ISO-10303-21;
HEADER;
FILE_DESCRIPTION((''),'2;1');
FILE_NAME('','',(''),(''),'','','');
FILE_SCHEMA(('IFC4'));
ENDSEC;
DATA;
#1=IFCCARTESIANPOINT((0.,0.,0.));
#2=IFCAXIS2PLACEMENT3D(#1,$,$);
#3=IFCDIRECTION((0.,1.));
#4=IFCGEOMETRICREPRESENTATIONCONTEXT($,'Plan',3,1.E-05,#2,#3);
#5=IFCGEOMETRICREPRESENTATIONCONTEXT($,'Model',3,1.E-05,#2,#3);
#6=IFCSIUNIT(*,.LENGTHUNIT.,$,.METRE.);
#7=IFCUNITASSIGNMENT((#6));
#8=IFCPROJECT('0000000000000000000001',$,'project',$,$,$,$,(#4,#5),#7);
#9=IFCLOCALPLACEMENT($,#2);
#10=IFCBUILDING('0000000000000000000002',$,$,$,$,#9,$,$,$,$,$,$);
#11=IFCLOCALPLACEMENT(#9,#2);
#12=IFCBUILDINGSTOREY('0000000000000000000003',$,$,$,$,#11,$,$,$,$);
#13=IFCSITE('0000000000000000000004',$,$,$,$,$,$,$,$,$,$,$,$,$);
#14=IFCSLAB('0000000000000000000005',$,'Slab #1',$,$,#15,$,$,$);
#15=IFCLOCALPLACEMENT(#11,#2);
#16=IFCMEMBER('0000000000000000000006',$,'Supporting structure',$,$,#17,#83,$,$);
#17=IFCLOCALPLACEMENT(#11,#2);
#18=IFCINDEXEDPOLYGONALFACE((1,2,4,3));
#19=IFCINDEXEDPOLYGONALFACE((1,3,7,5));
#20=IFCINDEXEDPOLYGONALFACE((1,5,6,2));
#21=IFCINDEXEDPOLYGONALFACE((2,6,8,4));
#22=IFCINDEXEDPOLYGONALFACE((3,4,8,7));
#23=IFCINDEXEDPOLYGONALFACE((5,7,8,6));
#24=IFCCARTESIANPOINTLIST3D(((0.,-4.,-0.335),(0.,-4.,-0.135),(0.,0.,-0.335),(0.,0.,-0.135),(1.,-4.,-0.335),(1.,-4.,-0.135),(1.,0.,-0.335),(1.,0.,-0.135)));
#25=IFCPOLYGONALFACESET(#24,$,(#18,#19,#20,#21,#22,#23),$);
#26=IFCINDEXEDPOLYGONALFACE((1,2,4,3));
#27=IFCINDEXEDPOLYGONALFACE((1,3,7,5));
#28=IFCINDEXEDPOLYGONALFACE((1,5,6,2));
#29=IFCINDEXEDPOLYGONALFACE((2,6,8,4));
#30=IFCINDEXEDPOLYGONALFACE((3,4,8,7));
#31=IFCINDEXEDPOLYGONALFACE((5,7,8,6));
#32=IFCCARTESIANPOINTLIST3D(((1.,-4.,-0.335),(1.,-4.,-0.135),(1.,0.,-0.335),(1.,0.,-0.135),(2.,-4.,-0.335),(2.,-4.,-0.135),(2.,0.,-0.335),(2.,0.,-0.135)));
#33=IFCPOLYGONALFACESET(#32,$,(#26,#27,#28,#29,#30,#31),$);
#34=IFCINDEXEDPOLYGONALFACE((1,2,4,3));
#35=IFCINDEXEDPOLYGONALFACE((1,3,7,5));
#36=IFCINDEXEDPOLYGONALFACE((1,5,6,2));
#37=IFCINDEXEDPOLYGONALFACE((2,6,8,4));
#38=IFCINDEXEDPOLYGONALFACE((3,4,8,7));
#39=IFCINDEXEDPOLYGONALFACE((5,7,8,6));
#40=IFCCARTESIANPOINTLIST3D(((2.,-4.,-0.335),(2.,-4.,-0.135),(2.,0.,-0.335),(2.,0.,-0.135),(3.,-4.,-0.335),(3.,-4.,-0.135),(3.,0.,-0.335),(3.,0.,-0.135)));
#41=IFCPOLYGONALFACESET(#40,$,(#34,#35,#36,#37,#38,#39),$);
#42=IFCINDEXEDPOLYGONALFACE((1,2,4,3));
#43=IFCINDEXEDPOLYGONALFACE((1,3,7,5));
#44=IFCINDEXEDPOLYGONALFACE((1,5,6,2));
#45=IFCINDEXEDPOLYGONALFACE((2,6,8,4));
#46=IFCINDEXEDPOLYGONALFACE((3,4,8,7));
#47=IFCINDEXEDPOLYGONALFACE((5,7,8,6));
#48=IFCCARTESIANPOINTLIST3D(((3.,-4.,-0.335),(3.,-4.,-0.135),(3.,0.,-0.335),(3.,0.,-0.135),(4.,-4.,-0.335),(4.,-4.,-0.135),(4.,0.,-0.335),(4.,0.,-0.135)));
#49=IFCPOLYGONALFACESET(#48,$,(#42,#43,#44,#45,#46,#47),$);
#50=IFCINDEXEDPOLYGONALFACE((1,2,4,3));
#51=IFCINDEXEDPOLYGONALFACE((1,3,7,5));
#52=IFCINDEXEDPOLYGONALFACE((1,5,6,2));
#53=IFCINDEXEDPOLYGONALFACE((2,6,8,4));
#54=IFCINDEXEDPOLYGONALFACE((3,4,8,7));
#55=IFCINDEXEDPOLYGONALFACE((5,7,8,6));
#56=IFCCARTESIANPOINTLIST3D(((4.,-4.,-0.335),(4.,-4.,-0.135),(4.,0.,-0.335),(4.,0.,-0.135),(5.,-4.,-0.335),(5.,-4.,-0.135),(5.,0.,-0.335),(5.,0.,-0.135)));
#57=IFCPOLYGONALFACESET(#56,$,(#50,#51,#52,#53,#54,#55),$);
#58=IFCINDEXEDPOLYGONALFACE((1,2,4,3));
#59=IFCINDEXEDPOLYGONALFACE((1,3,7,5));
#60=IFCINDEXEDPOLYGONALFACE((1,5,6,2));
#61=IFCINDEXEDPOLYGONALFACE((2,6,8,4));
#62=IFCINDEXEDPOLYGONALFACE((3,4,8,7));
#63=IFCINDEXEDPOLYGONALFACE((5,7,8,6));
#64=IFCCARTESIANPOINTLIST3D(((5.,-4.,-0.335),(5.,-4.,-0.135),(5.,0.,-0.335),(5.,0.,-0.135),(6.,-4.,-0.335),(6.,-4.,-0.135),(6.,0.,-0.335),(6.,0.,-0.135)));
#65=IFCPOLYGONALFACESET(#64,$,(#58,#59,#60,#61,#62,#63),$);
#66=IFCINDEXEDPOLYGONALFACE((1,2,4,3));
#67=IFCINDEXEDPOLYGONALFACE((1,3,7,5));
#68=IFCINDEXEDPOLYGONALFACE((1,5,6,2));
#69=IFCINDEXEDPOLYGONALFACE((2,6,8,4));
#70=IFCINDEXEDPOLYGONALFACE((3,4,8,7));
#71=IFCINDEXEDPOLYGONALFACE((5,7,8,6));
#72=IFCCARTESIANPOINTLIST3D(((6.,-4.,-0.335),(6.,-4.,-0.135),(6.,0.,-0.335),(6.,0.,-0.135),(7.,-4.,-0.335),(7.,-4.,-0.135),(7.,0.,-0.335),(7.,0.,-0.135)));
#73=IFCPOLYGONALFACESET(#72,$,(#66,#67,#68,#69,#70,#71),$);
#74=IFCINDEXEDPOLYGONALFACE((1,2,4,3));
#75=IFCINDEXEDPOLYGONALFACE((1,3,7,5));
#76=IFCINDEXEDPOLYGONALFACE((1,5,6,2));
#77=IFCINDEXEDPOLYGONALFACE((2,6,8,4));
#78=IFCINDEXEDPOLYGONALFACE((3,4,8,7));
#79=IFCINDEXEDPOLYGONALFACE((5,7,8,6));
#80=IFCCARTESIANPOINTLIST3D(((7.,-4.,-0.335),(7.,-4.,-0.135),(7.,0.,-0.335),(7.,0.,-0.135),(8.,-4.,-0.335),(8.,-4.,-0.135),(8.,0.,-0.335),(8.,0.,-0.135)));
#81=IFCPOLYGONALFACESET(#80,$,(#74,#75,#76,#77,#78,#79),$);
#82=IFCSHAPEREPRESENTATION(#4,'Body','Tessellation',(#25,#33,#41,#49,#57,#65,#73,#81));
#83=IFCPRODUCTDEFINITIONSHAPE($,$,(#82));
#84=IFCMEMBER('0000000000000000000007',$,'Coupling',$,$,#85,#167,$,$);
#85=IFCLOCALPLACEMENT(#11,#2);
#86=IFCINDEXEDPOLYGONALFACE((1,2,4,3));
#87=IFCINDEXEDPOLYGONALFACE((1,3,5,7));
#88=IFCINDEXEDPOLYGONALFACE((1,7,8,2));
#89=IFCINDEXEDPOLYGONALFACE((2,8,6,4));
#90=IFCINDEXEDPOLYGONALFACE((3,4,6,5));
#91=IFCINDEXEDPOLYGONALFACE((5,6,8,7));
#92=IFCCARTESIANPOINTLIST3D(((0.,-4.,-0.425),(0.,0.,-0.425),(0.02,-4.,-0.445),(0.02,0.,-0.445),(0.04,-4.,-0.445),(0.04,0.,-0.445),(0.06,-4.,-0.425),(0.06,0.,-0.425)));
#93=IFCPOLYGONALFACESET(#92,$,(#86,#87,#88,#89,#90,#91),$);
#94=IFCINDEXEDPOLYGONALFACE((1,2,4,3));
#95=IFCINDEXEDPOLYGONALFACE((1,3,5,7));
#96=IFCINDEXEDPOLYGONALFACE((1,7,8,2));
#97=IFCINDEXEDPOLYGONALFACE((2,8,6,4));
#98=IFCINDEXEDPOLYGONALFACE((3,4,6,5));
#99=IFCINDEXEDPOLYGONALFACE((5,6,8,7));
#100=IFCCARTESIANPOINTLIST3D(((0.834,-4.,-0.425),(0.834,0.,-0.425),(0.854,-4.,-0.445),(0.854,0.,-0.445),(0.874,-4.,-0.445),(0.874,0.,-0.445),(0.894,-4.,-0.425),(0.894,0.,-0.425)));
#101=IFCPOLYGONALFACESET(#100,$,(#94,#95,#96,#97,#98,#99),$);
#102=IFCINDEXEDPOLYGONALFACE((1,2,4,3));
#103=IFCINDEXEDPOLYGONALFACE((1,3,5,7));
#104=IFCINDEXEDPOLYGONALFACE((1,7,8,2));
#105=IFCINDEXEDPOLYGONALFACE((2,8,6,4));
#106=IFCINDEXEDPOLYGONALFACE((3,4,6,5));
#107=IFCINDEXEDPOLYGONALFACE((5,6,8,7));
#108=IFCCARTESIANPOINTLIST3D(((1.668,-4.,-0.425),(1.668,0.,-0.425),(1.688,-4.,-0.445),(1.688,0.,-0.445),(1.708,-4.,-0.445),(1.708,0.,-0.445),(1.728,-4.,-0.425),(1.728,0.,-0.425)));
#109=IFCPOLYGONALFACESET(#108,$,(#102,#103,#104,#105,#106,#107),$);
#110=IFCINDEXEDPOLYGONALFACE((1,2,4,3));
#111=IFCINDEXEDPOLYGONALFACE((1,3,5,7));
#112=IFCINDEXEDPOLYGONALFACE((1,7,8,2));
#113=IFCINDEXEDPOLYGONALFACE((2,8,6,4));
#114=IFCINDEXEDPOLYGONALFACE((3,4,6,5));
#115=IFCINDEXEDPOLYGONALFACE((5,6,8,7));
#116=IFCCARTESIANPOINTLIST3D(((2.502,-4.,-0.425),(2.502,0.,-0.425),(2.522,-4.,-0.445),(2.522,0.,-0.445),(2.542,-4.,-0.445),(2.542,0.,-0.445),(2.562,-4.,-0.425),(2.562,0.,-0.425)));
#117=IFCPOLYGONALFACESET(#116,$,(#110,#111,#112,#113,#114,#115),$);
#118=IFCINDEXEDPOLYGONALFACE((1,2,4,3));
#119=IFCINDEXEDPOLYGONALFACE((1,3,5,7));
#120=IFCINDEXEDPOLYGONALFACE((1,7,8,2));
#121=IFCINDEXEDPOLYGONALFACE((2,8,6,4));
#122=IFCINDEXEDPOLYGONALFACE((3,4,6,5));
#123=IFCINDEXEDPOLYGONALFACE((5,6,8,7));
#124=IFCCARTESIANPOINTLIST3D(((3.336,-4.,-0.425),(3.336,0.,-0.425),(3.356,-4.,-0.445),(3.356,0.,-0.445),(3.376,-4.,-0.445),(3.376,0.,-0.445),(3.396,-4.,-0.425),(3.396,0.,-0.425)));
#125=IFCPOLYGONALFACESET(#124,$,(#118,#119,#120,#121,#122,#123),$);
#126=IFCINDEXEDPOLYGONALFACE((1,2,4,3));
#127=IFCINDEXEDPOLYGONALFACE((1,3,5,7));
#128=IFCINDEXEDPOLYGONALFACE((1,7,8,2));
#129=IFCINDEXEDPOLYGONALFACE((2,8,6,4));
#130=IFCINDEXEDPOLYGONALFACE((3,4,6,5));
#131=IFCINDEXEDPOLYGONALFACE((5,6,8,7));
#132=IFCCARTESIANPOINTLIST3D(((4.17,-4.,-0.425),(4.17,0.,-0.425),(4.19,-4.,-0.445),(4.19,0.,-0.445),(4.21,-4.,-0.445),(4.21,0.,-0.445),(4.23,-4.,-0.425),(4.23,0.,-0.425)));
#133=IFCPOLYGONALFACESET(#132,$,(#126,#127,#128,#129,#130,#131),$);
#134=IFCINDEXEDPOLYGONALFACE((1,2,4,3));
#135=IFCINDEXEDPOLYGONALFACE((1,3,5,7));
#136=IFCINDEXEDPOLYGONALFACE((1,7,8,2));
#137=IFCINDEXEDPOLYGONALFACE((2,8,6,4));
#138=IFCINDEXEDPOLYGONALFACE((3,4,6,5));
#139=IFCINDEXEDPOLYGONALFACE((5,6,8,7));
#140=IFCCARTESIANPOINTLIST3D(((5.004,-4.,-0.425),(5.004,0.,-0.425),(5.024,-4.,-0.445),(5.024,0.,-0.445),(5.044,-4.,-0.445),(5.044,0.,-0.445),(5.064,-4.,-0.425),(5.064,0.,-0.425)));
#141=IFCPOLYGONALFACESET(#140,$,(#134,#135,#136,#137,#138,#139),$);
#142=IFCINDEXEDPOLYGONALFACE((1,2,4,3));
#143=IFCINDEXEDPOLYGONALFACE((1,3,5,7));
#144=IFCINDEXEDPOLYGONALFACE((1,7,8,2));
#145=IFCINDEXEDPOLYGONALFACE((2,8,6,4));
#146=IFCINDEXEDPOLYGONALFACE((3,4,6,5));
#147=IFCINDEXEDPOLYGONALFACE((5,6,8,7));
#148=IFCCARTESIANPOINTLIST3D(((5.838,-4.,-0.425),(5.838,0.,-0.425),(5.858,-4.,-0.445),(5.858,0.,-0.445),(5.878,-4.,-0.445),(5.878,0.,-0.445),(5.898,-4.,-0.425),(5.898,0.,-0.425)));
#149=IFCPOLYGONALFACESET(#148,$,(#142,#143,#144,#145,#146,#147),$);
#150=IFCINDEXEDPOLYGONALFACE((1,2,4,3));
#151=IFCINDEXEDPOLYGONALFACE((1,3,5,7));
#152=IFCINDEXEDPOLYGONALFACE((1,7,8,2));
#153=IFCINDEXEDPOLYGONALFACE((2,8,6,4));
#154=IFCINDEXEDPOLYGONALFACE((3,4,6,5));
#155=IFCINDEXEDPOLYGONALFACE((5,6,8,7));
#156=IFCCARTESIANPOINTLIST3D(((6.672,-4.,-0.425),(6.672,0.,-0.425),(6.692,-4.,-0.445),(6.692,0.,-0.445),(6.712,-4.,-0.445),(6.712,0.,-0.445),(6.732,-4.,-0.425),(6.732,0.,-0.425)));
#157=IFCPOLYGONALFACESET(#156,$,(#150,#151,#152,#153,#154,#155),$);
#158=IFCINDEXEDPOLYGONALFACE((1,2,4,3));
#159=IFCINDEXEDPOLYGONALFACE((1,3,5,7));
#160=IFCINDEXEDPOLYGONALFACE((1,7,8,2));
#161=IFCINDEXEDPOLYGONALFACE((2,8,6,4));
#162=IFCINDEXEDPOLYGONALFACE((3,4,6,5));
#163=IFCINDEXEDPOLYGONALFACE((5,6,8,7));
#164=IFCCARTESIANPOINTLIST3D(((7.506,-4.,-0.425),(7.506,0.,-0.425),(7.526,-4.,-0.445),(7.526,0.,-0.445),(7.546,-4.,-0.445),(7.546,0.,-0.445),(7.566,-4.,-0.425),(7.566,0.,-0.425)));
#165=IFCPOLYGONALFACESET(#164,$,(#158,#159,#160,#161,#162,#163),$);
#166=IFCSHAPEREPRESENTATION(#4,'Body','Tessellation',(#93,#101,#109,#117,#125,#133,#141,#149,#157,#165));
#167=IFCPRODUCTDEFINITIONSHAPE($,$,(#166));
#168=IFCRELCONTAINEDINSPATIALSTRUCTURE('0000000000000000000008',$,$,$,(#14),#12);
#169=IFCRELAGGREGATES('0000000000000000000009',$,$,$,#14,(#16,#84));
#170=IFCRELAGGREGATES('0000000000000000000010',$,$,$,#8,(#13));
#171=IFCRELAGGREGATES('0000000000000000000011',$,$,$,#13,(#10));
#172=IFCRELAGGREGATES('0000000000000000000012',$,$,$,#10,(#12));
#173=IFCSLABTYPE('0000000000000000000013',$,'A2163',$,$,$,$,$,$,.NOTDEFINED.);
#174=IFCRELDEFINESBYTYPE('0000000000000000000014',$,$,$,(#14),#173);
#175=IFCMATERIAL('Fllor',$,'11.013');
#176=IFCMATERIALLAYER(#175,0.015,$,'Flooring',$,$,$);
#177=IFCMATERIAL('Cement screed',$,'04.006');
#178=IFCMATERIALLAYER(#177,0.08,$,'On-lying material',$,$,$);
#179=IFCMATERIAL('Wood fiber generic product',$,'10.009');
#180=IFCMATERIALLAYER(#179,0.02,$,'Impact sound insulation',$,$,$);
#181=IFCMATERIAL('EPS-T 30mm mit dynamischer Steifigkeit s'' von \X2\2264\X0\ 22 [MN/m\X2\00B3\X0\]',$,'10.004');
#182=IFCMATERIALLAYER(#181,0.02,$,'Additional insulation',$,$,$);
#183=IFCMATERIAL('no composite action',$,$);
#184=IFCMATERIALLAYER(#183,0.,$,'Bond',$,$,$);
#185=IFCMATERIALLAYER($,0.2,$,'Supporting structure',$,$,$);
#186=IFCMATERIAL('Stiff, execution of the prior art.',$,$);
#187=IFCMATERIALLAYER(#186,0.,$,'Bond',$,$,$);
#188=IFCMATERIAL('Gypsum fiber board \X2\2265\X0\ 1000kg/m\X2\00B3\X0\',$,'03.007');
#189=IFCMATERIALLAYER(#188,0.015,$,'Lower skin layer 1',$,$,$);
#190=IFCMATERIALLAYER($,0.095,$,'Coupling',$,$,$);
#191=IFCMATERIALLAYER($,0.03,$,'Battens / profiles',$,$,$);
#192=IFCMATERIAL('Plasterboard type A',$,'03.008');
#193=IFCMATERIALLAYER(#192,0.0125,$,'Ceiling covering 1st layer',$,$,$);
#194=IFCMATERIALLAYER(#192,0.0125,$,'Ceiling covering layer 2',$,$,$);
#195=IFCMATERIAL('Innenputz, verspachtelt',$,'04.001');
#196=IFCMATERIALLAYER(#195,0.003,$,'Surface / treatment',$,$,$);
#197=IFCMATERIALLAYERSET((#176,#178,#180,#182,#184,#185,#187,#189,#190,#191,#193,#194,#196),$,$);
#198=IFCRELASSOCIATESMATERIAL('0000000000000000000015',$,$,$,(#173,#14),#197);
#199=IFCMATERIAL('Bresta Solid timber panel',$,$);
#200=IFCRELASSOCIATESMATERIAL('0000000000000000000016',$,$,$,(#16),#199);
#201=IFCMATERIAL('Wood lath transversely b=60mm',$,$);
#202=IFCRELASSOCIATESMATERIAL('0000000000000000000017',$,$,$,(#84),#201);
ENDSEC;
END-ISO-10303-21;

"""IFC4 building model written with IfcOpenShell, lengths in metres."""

from ifc_helpers import new_model, si_unit, direction, frame, frame_2d, origin, place, context, project, spatial, polyline, rectangle, outline, extrude, material, layer, layer_set, type_object, element, aggregate, save


model = new_model("IFC4")

# Units and contexts
plan_context = context("Plan", 3, precision=1e-05, world=origin(), true_north=direction((0.0, 1.0)))
model_context = context("Model", 3, precision=1e-05, world=origin(), true_north=direction((0.0, 1.0)))
ifc_project = project(units=[si_unit("LENGTHUNIT", "METRE")], contexts=[plan_context, model_context])

# Site, building, storey
site = spatial("IfcSite", under=ifc_project)
building_placement = place(None, origin())
building = spatial("IfcBuilding", under=site, at=building_placement)
storey_placement = place(building_placement, origin())
storey = spatial("IfcBuildingStorey", under=building, at=storey_placement)

# Slab, members
ifc_material_1 = material(Name="Fllor", Category="11.013")
ifc_layer_1 = layer(ifc_material_1, 0.015, Name="Flooring")
ifc_material_2 = material(Name="Cement screed", Category="04.006")
ifc_layer_2 = layer(ifc_material_2, 0.08, Name="On-lying material")
ifc_material_3 = material(Name="Wood fiber generic product", Category="10.009")
ifc_layer_3 = layer(ifc_material_3, 0.02, Name="Impact sound insulation")
ifc_material_4 = material(Name="EPS-T 30mm mit dynamischer Steifigkeit s' von ≤ 22 [MN/m³]", Category="10.004")
ifc_layer_4 = layer(ifc_material_4, 0.02, Name="Additional insulation")
ifc_material_5 = material(Name="no composite action")
ifc_layer_5 = layer(ifc_material_5, 0.0, Name="Bond")
ifc_layer_6 = layer(None, 0.2, Name="Supporting structure")
ifc_material_6 = material(Name="Stiff, execution of the prior art.")
ifc_layer_7 = layer(ifc_material_6, 0.0, Name="Bond")
ifc_material_7 = material(Name="Gypsum fiber board ≥ 1000kg/m³", Category="03.007")
ifc_layer_8 = layer(ifc_material_7, 0.015, Name="Lower skin layer 1")
ifc_layer_9 = layer(None, 0.095, Name="Coupling")
ifc_layer_10 = layer(None, 0.03, Name="Battens / profiles")
ifc_material_8 = material(Name="Plasterboard type A", Category="03.008")
ifc_layer_11 = layer(ifc_material_8, 0.0125, Name="Ceiling covering 1st layer")
ifc_layer_12 = layer(ifc_material_8, 0.0125, Name="Ceiling covering layer 2")
ifc_material_9 = material(Name="Innenputz, verspachtelt", Category="04.001")
ifc_layer_13 = layer(ifc_material_9, 0.003, Name="Surface / treatment")
ifc_layer_set = layer_set([ifc_layer_1, ifc_layer_2, ifc_layer_3, ifc_layer_4, ifc_layer_5, ifc_layer_6, ifc_layer_7, ifc_layer_8, ifc_layer_9, ifc_layer_10, ifc_layer_11, ifc_layer_12, ifc_layer_13])
slab_type = type_object("IfcSlabType", Name="A2163", PredefinedType="NOTDEFINED", material=ifc_layer_set)
slab_placement = place(None, frame((0.0, 0.0, 0.0), z_axis=(0.0, 0.0, -1.0), x_axis=(1.0, 0.0, 0.0)))
slab = element("IfcSlab", 1, at=slab_placement, inside=storey, type_object=slab_type, material=ifc_layer_set, Name="Slab #1")
ifc_material_10 = material(Name="Bresta Solid timber panel")
member_1_placement = place(slab_placement, origin())
member_1 = element("IfcMember", 2, at=member_1_placement, material=ifc_material_10, Name="Supporting structure", context=plan_context, shape_type="SweptSolid", body=[
    extrude(rectangle(XDim=1.0, YDim=0.2, at=frame_2d((0.5, 0.1), x_axis=(1.0, 0.0))), frame((0.0, 4.0, 0.135), z_axis=(0.0, -1.0, 0.0), x_axis=(1.0, 0.0, 0.0)), (0.0, 0.0, 1.0), 4.0),
    extrude(rectangle(XDim=1.0, YDim=0.2, at=frame_2d((0.5, 0.1), x_axis=(1.0, 0.0))), frame((1.0, 4.0, 0.135), z_axis=(0.0, -1.0, 0.0), x_axis=(1.0, 0.0, 0.0)), (0.0, 0.0, 1.0), 4.0),
    extrude(rectangle(XDim=1.0, YDim=0.2, at=frame_2d((0.5, 0.1), x_axis=(1.0, 0.0))), frame((2.0, 4.0, 0.135), z_axis=(0.0, -1.0, 0.0), x_axis=(1.0, 0.0, 0.0)), (0.0, 0.0, 1.0), 4.0),
    extrude(rectangle(XDim=1.0, YDim=0.2, at=frame_2d((0.5, 0.1), x_axis=(1.0, 0.0))), frame((3.0, 4.0, 0.135), z_axis=(0.0, -1.0, 0.0), x_axis=(1.0, 0.0, 0.0)), (0.0, 0.0, 1.0), 4.0),
    extrude(rectangle(XDim=1.0, YDim=0.2, at=frame_2d((0.5, 0.1), x_axis=(1.0, 0.0))), frame((4.0, 4.0, 0.135), z_axis=(0.0, -1.0, 0.0), x_axis=(1.0, 0.0, 0.0)), (0.0, 0.0, 1.0), 4.0),
    extrude(rectangle(XDim=1.0, YDim=0.2, at=frame_2d((0.5, 0.1), x_axis=(1.0, 0.0))), frame((5.0, 4.0, 0.135), z_axis=(0.0, -1.0, 0.0), x_axis=(1.0, 0.0, 0.0)), (0.0, 0.0, 1.0), 4.0),
    extrude(rectangle(XDim=1.0, YDim=0.2, at=frame_2d((0.5, 0.1), x_axis=(1.0, 0.0))), frame((6.0, 4.0, 0.135), z_axis=(0.0, -1.0, 0.0), x_axis=(1.0, 0.0, 0.0)), (0.0, 0.0, 1.0), 4.0),
    extrude(rectangle(XDim=1.0, YDim=0.2, at=frame_2d((0.5, 0.1), x_axis=(1.0, 0.0))), frame((7.0, 4.0, 0.135), z_axis=(0.0, -1.0, 0.0), x_axis=(1.0, 0.0, 0.0)), (0.0, 0.0, 1.0), 4.0),
])
ifc_material_11 = material(Name="Wood lath transversely b=60mm")
member_2_placement = place(slab_placement, origin())
member_2 = element("IfcMember", 3, at=member_2_placement, material=ifc_material_11, Name="Coupling", context=plan_context, shape_type="SweptSolid", body=[
    extrude(outline(polyline([(0.0, 0.0), (0.06, 0.0), (0.04, 0.02), (0.02, 0.02), (0.0, 0.0)])), frame((0.0, 4.0, 0.425), z_axis=(0.0, -1.0, 0.0), x_axis=(1.0, 0.0, 0.0)), (0.0, 0.0, 1.0), 4.0),
    extrude(outline(polyline([(0.0, 0.0), (0.06, 0.0), (0.04, 0.02), (0.02, 0.02), (0.0, 0.0)])), frame((0.834, 4.0, 0.425), z_axis=(0.0, -1.0, 0.0), x_axis=(1.0, 0.0, 0.0)), (0.0, 0.0, 1.0), 4.0),
    extrude(outline(polyline([(0.0, 0.0), (0.06, 0.0), (0.04, 0.02), (0.02, 0.02), (0.0, 0.0)])), frame((1.668, 4.0, 0.425), z_axis=(0.0, -1.0, 0.0), x_axis=(1.0, 0.0, 0.0)), (0.0, 0.0, 1.0), 4.0),
    extrude(outline(polyline([(0.0, 0.0), (0.06, 0.0), (0.04, 0.02), (0.02, 0.02), (0.0, 0.0)])), frame((2.502, 4.0, 0.425), z_axis=(0.0, -1.0, 0.0), x_axis=(1.0, 0.0, 0.0)), (0.0, 0.0, 1.0), 4.0),
    extrude(outline(polyline([(0.0, 0.0), (0.06, 0.0), (0.04, 0.02), (0.02, 0.02), (0.0, 0.0)])), frame((3.336, 4.0, 0.425), z_axis=(0.0, -1.0, 0.0), x_axis=(1.0, 0.0, 0.0)), (0.0, 0.0, 1.0), 4.0),
    extrude(outline(polyline([(0.0, 0.0), (0.06, 0.0), (0.04, 0.02), (0.02, 0.02), (0.0, 0.0)])), frame((4.17, 4.0, 0.425), z_axis=(0.0, -1.0, 0.0), x_axis=(1.0, 0.0, 0.0)), (0.0, 0.0, 1.0), 4.0),
    extrude(outline(polyline([(0.0, 0.0), (0.06, 0.0), (0.04, 0.02), (0.02, 0.02), (0.0, 0.0)])), frame((5.004, 4.0, 0.425), z_axis=(0.0, -1.0, 0.0), x_axis=(1.0, 0.0, 0.0)), (0.0, 0.0, 1.0), 4.0),
    extrude(outline(polyline([(0.0, 0.0), (0.06, 0.0), (0.04, 0.02), (0.02, 0.02), (0.0, 0.0)])), frame((5.838, 4.0, 0.425), z_axis=(0.0, -1.0, 0.0), x_axis=(1.0, 0.0, 0.0)), (0.0, 0.0, 1.0), 4.0),
    extrude(outline(polyline([(0.0, 0.0), (0.06, 0.0), (0.04, 0.02), (0.02, 0.02), (0.0, 0.0)])), frame((6.672, 4.0, 0.425), z_axis=(0.0, -1.0, 0.0), x_axis=(1.0, 0.0, 0.0)), (0.0, 0.0, 1.0), 4.0),
    extrude(outline(polyline([(0.0, 0.0), (0.06, 0.0), (0.04, 0.02), (0.02, 0.02), (0.0, 0.0)])), frame((7.506, 4.0, 0.425), z_axis=(0.0, -1.0, 0.0), x_axis=(1.0, 0.0, 0.0)), (0.0, 0.0, 1.0), 4.0),
])
aggregate(slab, [member_1, member_2])

save(model, "model.ifc")
